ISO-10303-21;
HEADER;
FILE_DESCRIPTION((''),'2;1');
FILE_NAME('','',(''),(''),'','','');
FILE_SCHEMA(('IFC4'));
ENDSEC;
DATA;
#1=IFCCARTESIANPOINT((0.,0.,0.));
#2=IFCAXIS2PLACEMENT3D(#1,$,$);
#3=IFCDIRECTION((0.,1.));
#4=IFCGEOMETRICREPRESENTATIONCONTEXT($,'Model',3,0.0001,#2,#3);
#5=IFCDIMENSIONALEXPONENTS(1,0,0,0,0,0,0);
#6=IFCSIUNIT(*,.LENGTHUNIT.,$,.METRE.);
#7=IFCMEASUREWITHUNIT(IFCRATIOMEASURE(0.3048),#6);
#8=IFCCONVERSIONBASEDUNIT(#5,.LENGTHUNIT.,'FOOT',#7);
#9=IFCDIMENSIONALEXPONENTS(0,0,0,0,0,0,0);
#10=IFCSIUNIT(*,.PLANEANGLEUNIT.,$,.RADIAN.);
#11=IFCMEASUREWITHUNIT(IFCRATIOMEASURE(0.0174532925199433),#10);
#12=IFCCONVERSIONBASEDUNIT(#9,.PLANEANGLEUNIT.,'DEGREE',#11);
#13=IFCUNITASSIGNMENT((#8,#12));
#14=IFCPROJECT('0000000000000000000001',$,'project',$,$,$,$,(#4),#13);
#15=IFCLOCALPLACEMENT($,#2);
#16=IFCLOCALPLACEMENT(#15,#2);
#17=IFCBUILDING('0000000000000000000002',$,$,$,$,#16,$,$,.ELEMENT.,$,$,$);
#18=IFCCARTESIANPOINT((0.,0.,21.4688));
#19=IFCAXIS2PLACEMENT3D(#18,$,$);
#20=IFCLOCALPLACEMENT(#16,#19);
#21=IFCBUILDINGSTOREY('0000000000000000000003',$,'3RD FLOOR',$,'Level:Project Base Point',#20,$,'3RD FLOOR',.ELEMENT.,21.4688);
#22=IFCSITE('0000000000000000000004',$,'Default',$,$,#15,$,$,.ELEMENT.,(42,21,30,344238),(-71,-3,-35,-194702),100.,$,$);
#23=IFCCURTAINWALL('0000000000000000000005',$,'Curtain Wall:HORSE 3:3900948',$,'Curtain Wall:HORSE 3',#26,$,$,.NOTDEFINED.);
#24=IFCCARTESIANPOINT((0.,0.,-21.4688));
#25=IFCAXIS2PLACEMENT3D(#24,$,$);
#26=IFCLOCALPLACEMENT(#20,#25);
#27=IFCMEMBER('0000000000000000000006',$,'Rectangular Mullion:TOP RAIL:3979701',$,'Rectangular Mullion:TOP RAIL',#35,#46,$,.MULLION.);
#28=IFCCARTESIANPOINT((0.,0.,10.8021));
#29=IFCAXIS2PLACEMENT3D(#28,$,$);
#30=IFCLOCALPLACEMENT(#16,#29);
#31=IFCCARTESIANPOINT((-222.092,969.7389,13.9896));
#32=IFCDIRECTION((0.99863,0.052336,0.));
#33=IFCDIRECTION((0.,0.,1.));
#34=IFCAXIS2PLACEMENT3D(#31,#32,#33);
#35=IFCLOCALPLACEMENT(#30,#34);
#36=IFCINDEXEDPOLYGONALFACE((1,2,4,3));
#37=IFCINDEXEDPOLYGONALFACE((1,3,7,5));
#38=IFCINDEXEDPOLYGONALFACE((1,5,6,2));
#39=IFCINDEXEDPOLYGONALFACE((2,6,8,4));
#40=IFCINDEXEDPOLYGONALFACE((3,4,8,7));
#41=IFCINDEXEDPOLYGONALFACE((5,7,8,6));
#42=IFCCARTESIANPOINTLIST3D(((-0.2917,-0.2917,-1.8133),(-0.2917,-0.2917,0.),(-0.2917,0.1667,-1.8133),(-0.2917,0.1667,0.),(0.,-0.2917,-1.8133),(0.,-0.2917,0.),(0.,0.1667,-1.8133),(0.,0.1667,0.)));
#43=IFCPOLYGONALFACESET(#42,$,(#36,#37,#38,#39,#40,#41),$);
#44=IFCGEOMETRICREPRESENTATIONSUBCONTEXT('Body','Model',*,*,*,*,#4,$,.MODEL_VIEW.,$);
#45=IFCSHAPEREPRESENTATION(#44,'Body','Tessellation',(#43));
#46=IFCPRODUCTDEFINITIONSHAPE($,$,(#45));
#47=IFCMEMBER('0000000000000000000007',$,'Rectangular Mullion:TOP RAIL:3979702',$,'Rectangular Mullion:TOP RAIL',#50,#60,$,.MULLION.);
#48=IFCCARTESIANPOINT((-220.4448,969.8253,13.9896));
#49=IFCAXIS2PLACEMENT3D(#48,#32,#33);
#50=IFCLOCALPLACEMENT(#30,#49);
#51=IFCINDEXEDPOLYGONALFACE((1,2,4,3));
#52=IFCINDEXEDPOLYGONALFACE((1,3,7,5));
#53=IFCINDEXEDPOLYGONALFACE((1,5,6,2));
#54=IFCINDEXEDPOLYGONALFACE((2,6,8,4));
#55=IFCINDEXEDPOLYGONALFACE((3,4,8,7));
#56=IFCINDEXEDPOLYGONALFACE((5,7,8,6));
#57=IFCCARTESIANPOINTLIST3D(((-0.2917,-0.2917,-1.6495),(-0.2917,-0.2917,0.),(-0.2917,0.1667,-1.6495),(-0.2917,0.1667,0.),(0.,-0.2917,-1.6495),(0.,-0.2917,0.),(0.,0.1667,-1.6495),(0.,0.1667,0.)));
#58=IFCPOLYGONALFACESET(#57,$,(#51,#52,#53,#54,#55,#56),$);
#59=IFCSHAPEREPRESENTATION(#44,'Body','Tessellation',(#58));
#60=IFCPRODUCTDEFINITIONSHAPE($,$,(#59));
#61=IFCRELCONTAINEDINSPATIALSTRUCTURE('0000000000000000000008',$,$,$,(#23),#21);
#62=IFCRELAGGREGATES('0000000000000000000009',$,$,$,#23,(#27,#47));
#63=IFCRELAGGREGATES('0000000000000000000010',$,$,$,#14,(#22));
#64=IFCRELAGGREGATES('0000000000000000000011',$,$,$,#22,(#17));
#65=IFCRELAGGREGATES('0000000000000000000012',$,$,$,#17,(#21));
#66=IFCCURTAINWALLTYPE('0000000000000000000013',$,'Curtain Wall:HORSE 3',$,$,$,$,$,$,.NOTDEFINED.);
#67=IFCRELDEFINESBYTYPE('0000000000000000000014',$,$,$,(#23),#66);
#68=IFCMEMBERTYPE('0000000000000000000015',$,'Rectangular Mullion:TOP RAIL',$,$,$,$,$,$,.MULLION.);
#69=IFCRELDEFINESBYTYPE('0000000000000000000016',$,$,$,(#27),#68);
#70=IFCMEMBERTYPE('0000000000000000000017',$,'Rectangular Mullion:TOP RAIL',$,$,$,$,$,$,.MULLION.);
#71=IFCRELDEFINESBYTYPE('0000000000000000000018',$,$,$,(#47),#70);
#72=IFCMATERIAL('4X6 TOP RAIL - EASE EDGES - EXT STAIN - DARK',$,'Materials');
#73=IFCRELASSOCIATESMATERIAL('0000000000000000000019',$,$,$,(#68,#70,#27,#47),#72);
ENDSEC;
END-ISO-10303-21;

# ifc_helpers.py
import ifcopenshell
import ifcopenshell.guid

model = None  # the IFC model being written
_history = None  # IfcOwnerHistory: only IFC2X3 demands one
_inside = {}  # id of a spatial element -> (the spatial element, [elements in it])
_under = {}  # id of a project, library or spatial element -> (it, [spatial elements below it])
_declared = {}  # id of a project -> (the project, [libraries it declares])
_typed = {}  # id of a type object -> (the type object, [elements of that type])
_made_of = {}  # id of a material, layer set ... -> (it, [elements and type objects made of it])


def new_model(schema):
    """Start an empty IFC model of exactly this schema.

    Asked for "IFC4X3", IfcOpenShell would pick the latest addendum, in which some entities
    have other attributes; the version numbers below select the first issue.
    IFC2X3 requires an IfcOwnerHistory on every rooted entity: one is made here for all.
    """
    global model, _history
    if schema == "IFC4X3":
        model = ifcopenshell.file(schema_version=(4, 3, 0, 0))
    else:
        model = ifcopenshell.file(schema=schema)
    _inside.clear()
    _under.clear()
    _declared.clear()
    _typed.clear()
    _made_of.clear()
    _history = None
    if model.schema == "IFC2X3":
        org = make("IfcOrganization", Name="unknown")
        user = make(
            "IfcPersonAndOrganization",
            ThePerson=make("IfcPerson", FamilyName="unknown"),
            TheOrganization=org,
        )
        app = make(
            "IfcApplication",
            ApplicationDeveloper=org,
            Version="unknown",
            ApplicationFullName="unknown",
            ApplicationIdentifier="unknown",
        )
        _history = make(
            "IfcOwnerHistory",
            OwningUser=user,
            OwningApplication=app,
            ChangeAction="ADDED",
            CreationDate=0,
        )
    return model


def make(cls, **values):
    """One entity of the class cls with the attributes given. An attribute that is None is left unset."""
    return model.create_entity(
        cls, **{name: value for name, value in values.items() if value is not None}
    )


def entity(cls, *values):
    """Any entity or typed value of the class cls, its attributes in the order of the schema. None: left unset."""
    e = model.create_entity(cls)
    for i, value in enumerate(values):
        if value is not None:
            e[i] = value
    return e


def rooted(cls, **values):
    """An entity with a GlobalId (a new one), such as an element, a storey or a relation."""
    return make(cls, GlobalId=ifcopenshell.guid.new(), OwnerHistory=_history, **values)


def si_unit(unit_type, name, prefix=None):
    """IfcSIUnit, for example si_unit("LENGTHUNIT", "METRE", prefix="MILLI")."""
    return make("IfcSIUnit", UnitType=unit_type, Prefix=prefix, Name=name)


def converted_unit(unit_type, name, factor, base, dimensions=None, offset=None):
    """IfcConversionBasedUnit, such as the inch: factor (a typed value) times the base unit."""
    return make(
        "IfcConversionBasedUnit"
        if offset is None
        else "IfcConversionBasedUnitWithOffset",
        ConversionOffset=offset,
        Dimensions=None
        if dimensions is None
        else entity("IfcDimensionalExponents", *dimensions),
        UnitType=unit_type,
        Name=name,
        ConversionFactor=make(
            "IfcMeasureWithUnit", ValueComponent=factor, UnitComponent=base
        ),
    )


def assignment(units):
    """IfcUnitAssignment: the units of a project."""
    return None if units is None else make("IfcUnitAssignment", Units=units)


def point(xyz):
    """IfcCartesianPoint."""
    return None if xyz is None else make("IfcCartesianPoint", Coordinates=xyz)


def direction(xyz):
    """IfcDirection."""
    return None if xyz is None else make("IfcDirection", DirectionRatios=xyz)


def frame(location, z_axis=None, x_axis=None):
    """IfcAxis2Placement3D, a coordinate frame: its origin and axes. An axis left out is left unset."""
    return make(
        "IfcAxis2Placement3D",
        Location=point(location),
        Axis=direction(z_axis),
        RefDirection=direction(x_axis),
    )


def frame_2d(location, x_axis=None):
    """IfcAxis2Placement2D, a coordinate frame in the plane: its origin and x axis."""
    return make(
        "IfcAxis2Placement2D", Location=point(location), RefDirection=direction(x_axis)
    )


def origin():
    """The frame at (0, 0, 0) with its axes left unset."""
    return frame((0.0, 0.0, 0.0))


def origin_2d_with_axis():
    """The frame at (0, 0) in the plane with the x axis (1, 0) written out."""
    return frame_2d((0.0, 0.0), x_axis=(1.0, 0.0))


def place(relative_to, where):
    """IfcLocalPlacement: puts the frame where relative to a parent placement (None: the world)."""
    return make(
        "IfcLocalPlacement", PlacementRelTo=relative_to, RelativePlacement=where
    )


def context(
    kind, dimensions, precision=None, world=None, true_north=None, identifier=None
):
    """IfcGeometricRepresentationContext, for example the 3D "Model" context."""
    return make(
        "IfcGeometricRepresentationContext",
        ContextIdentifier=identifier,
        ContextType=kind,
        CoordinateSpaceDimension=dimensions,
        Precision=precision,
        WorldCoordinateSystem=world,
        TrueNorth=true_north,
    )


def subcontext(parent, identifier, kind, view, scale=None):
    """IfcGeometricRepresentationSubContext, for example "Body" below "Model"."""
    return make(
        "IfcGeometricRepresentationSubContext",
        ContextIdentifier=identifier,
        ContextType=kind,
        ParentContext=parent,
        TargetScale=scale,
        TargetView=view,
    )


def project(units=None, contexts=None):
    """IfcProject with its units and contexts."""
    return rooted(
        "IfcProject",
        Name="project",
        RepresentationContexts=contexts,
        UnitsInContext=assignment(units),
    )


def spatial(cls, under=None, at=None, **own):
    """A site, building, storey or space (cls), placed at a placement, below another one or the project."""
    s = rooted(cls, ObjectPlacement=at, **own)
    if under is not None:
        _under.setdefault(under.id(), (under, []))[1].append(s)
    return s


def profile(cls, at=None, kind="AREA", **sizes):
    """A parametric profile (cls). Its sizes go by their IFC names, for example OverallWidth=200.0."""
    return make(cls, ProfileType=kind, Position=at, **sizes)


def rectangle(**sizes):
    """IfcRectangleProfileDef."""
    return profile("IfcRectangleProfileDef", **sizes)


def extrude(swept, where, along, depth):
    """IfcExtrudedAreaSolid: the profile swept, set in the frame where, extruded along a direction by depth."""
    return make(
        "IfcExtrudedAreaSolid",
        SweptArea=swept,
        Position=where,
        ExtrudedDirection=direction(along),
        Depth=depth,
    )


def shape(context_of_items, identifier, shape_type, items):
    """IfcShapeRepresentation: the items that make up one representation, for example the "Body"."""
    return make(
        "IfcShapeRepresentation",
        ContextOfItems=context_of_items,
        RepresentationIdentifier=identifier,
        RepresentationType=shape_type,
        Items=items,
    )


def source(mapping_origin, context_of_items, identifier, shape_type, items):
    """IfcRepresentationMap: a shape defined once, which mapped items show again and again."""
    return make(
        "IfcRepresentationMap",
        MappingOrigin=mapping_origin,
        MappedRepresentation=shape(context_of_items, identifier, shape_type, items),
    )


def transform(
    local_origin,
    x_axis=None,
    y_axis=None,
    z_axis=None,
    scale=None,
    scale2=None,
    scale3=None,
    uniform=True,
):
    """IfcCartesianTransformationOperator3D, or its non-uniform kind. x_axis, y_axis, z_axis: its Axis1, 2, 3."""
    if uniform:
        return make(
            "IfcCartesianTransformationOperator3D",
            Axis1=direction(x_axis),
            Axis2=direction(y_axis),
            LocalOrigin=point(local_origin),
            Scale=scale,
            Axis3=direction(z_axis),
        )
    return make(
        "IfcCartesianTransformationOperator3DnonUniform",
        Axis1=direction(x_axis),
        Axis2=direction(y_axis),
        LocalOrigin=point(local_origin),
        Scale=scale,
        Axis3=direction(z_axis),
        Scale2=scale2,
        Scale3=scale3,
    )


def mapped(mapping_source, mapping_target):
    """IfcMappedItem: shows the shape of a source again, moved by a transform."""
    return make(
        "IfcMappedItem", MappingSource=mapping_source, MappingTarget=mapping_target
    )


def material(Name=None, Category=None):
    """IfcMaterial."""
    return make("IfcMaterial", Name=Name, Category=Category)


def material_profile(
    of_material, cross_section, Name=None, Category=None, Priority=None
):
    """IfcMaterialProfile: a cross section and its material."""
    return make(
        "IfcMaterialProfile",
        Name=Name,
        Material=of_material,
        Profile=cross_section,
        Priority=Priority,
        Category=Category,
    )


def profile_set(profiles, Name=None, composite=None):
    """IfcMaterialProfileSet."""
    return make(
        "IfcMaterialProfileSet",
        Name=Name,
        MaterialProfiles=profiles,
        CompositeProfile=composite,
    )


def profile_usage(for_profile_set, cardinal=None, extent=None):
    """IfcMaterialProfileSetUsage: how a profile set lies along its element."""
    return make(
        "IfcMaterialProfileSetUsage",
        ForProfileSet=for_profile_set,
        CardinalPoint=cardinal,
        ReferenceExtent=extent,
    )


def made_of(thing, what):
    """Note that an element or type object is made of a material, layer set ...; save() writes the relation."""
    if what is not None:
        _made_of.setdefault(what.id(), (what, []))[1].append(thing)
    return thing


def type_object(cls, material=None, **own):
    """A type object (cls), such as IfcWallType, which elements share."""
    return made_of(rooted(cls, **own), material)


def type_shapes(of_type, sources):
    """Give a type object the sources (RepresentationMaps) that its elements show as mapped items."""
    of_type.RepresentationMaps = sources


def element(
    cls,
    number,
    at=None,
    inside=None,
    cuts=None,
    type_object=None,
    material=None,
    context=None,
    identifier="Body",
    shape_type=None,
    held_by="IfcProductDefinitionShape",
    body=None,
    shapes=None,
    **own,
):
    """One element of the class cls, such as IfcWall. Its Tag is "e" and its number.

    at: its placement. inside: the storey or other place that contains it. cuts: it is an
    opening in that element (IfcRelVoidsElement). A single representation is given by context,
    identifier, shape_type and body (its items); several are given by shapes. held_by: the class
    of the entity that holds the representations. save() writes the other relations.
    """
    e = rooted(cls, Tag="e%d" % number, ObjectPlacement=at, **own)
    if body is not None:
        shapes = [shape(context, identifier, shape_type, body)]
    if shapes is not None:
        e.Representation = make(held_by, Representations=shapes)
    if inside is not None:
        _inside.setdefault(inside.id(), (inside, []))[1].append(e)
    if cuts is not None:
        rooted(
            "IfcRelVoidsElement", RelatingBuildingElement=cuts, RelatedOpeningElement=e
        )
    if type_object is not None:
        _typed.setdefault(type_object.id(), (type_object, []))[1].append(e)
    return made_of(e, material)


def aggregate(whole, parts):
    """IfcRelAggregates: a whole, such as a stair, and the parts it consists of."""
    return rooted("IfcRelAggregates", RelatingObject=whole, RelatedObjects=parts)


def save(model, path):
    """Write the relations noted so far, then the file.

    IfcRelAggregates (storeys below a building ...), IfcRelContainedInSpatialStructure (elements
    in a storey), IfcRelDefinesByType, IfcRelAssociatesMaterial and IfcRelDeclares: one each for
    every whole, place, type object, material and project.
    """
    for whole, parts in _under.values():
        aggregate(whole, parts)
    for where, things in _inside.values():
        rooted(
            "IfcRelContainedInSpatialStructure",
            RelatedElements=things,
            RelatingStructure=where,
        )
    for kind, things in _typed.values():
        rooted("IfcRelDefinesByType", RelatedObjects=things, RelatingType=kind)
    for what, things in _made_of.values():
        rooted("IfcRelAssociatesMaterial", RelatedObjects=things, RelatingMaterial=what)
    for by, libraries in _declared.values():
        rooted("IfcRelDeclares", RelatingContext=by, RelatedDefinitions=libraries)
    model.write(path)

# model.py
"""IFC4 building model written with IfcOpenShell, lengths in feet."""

from ifc_helpers import new_model, entity, si_unit, converted_unit, direction, frame, origin, origin_2d_with_axis, place, context, subcontext, project, spatial, rectangle, extrude, source, transform, mapped, material, material_profile, profile_set, profile_usage, type_object, type_shapes, element, aggregate, save


model = new_model("IFC4")

# Units and contexts
model_context = context("Model", 3, precision=0.0001, world=origin(), true_north=direction((0.0, 1.0)))
body_context = subcontext(model_context, "Body", "Model", "MODEL_VIEW")
ifc_project = project(units=[converted_unit("LENGTHUNIT", "FOOT", entity("IfcRatioMeasure", 0.3048), si_unit("LENGTHUNIT", "METRE"), dimensions=[1, 0, 0, 0, 0, 0, 0]), converted_unit("PLANEANGLEUNIT", "DEGREE", entity("IfcRatioMeasure", 0.0174532925199433), si_unit("PLANEANGLEUNIT", "RADIAN"), dimensions=[0, 0, 0, 0, 0, 0, 0])], contexts=[model_context])

# Site, building, storey
site_placement = place(None, origin())
site = spatial("IfcSite", under=ifc_project, at=site_placement, Name="Default", CompositionType="ELEMENT", RefLatitude=(42, 21, 30, 344238), RefLongitude=(-71, -3, -35, -194702), RefElevation=100.0)
building_placement = place(site_placement, origin())
building = spatial("IfcBuilding", under=site, at=building_placement, CompositionType="ELEMENT")
storey_placement = place(building_placement, frame((0.0, 0.0, 21.4688)))
storey = spatial("IfcBuildingStorey", under=building, at=storey_placement, Name="3RD FLOOR", ObjectType="Level:Project Base Point", LongName="3RD FLOOR", CompositionType="ELEMENT", Elevation=21.4688)

# Shared definitions
curtain_wall_type_1 = type_object("IfcCurtainWallType", Name="Curtain Wall:HORSE 3", PredefinedType="NOTDEFINED")

# Curtain wall
curtain_wall_1_placement = place(storey_placement, frame((0.0, 0.0, -21.4688)))
curtain_wall_1 = element("IfcCurtainWall", 1, at=curtain_wall_1_placement, inside=storey, type_object=curtain_wall_type_1, Name="Curtain Wall:HORSE 3:3900948", ObjectType="Curtain Wall:HORSE 3", PredefinedType="NOTDEFINED")

# Members
ifc_material_1 = material(Name="4X6 TOP RAIL - EASE EDGES - EXT STAIN - DARK", Category="Materials")
ifc_material_profile_1 = material_profile(ifc_material_1, rectangle(XDim=0.4583, YDim=0.2917, at=origin_2d_with_axis()), Name="TOP RAIL")
ifc_profile_set_1 = profile_set([ifc_material_profile_1], Name="TOP RAIL")
ifc_profile_usage_1 = profile_usage(ifc_profile_set_1)
member_type_1 = type_object("IfcMemberType", Name="Rectangular Mullion:TOP RAIL", PredefinedType="MULLION", material=ifc_profile_set_1)
shared_shape_1 = source(origin(), body_context, "Body", "SweptSolid", [
    extrude(rectangle(XDim=0.4583, YDim=0.2917, at=origin_2d_with_axis()), frame((-0.1458, -0.0625, -1.8133), z_axis=(0.0, 0.0, 1.0), x_axis=(0.0, -1.0, 0.0)), (0.0, 0.0, 1.0), 1.8133),
])
type_shapes(member_type_1, [shared_shape_1])
placement = place(building_placement, frame((0.0, 0.0, 10.8021)))
member_1_placement = place(placement, frame((-222.092, 969.7389, 13.9896), z_axis=(0.99863, 0.052336, 0.0), x_axis=(0.0, 0.0, 1.0)))
member_1 = element("IfcMember", 2, at=member_1_placement, type_object=member_type_1, material=ifc_profile_usage_1, Name="Rectangular Mullion:TOP RAIL:3979701", ObjectType="Rectangular Mullion:TOP RAIL", PredefinedType="MULLION", context=body_context, shape_type="MappedRepresentation", body=[
    mapped(shared_shape_1, transform((0.0, 0.0, 0.0), scale=1.0)),
])
ifc_profile_usage_2 = profile_usage(ifc_profile_set_1)
member_type_2 = type_object("IfcMemberType", Name="Rectangular Mullion:TOP RAIL", PredefinedType="MULLION", material=ifc_profile_set_1)
shared_shape_2 = source(origin(), body_context, "Body", "SweptSolid", [
    extrude(rectangle(XDim=0.4583, YDim=0.2917, at=origin_2d_with_axis()), frame((-0.1458, -0.0625, -1.6495), z_axis=(0.0, 0.0, 1.0), x_axis=(0.0, -1.0, 0.0)), (0.0, 0.0, 1.0), 1.6495),
])
type_shapes(member_type_2, [shared_shape_2])
member_2_placement = place(placement, frame((-220.4448, 969.8253, 13.9896), z_axis=(0.99863, 0.052336, 0.0), x_axis=(0.0, 0.0, 1.0)))
member_2 = element("IfcMember", 3, at=member_2_placement, type_object=member_type_2, material=ifc_profile_usage_2, Name="Rectangular Mullion:TOP RAIL:3979702", ObjectType="Rectangular Mullion:TOP RAIL", PredefinedType="MULLION", context=body_context, shape_type="MappedRepresentation", body=[
    mapped(shared_shape_2, transform((0.0, 0.0, 0.0), scale=1.0)),
])

aggregate(curtain_wall_1, [member_1, member_2])

save(model, "model.ifc")
